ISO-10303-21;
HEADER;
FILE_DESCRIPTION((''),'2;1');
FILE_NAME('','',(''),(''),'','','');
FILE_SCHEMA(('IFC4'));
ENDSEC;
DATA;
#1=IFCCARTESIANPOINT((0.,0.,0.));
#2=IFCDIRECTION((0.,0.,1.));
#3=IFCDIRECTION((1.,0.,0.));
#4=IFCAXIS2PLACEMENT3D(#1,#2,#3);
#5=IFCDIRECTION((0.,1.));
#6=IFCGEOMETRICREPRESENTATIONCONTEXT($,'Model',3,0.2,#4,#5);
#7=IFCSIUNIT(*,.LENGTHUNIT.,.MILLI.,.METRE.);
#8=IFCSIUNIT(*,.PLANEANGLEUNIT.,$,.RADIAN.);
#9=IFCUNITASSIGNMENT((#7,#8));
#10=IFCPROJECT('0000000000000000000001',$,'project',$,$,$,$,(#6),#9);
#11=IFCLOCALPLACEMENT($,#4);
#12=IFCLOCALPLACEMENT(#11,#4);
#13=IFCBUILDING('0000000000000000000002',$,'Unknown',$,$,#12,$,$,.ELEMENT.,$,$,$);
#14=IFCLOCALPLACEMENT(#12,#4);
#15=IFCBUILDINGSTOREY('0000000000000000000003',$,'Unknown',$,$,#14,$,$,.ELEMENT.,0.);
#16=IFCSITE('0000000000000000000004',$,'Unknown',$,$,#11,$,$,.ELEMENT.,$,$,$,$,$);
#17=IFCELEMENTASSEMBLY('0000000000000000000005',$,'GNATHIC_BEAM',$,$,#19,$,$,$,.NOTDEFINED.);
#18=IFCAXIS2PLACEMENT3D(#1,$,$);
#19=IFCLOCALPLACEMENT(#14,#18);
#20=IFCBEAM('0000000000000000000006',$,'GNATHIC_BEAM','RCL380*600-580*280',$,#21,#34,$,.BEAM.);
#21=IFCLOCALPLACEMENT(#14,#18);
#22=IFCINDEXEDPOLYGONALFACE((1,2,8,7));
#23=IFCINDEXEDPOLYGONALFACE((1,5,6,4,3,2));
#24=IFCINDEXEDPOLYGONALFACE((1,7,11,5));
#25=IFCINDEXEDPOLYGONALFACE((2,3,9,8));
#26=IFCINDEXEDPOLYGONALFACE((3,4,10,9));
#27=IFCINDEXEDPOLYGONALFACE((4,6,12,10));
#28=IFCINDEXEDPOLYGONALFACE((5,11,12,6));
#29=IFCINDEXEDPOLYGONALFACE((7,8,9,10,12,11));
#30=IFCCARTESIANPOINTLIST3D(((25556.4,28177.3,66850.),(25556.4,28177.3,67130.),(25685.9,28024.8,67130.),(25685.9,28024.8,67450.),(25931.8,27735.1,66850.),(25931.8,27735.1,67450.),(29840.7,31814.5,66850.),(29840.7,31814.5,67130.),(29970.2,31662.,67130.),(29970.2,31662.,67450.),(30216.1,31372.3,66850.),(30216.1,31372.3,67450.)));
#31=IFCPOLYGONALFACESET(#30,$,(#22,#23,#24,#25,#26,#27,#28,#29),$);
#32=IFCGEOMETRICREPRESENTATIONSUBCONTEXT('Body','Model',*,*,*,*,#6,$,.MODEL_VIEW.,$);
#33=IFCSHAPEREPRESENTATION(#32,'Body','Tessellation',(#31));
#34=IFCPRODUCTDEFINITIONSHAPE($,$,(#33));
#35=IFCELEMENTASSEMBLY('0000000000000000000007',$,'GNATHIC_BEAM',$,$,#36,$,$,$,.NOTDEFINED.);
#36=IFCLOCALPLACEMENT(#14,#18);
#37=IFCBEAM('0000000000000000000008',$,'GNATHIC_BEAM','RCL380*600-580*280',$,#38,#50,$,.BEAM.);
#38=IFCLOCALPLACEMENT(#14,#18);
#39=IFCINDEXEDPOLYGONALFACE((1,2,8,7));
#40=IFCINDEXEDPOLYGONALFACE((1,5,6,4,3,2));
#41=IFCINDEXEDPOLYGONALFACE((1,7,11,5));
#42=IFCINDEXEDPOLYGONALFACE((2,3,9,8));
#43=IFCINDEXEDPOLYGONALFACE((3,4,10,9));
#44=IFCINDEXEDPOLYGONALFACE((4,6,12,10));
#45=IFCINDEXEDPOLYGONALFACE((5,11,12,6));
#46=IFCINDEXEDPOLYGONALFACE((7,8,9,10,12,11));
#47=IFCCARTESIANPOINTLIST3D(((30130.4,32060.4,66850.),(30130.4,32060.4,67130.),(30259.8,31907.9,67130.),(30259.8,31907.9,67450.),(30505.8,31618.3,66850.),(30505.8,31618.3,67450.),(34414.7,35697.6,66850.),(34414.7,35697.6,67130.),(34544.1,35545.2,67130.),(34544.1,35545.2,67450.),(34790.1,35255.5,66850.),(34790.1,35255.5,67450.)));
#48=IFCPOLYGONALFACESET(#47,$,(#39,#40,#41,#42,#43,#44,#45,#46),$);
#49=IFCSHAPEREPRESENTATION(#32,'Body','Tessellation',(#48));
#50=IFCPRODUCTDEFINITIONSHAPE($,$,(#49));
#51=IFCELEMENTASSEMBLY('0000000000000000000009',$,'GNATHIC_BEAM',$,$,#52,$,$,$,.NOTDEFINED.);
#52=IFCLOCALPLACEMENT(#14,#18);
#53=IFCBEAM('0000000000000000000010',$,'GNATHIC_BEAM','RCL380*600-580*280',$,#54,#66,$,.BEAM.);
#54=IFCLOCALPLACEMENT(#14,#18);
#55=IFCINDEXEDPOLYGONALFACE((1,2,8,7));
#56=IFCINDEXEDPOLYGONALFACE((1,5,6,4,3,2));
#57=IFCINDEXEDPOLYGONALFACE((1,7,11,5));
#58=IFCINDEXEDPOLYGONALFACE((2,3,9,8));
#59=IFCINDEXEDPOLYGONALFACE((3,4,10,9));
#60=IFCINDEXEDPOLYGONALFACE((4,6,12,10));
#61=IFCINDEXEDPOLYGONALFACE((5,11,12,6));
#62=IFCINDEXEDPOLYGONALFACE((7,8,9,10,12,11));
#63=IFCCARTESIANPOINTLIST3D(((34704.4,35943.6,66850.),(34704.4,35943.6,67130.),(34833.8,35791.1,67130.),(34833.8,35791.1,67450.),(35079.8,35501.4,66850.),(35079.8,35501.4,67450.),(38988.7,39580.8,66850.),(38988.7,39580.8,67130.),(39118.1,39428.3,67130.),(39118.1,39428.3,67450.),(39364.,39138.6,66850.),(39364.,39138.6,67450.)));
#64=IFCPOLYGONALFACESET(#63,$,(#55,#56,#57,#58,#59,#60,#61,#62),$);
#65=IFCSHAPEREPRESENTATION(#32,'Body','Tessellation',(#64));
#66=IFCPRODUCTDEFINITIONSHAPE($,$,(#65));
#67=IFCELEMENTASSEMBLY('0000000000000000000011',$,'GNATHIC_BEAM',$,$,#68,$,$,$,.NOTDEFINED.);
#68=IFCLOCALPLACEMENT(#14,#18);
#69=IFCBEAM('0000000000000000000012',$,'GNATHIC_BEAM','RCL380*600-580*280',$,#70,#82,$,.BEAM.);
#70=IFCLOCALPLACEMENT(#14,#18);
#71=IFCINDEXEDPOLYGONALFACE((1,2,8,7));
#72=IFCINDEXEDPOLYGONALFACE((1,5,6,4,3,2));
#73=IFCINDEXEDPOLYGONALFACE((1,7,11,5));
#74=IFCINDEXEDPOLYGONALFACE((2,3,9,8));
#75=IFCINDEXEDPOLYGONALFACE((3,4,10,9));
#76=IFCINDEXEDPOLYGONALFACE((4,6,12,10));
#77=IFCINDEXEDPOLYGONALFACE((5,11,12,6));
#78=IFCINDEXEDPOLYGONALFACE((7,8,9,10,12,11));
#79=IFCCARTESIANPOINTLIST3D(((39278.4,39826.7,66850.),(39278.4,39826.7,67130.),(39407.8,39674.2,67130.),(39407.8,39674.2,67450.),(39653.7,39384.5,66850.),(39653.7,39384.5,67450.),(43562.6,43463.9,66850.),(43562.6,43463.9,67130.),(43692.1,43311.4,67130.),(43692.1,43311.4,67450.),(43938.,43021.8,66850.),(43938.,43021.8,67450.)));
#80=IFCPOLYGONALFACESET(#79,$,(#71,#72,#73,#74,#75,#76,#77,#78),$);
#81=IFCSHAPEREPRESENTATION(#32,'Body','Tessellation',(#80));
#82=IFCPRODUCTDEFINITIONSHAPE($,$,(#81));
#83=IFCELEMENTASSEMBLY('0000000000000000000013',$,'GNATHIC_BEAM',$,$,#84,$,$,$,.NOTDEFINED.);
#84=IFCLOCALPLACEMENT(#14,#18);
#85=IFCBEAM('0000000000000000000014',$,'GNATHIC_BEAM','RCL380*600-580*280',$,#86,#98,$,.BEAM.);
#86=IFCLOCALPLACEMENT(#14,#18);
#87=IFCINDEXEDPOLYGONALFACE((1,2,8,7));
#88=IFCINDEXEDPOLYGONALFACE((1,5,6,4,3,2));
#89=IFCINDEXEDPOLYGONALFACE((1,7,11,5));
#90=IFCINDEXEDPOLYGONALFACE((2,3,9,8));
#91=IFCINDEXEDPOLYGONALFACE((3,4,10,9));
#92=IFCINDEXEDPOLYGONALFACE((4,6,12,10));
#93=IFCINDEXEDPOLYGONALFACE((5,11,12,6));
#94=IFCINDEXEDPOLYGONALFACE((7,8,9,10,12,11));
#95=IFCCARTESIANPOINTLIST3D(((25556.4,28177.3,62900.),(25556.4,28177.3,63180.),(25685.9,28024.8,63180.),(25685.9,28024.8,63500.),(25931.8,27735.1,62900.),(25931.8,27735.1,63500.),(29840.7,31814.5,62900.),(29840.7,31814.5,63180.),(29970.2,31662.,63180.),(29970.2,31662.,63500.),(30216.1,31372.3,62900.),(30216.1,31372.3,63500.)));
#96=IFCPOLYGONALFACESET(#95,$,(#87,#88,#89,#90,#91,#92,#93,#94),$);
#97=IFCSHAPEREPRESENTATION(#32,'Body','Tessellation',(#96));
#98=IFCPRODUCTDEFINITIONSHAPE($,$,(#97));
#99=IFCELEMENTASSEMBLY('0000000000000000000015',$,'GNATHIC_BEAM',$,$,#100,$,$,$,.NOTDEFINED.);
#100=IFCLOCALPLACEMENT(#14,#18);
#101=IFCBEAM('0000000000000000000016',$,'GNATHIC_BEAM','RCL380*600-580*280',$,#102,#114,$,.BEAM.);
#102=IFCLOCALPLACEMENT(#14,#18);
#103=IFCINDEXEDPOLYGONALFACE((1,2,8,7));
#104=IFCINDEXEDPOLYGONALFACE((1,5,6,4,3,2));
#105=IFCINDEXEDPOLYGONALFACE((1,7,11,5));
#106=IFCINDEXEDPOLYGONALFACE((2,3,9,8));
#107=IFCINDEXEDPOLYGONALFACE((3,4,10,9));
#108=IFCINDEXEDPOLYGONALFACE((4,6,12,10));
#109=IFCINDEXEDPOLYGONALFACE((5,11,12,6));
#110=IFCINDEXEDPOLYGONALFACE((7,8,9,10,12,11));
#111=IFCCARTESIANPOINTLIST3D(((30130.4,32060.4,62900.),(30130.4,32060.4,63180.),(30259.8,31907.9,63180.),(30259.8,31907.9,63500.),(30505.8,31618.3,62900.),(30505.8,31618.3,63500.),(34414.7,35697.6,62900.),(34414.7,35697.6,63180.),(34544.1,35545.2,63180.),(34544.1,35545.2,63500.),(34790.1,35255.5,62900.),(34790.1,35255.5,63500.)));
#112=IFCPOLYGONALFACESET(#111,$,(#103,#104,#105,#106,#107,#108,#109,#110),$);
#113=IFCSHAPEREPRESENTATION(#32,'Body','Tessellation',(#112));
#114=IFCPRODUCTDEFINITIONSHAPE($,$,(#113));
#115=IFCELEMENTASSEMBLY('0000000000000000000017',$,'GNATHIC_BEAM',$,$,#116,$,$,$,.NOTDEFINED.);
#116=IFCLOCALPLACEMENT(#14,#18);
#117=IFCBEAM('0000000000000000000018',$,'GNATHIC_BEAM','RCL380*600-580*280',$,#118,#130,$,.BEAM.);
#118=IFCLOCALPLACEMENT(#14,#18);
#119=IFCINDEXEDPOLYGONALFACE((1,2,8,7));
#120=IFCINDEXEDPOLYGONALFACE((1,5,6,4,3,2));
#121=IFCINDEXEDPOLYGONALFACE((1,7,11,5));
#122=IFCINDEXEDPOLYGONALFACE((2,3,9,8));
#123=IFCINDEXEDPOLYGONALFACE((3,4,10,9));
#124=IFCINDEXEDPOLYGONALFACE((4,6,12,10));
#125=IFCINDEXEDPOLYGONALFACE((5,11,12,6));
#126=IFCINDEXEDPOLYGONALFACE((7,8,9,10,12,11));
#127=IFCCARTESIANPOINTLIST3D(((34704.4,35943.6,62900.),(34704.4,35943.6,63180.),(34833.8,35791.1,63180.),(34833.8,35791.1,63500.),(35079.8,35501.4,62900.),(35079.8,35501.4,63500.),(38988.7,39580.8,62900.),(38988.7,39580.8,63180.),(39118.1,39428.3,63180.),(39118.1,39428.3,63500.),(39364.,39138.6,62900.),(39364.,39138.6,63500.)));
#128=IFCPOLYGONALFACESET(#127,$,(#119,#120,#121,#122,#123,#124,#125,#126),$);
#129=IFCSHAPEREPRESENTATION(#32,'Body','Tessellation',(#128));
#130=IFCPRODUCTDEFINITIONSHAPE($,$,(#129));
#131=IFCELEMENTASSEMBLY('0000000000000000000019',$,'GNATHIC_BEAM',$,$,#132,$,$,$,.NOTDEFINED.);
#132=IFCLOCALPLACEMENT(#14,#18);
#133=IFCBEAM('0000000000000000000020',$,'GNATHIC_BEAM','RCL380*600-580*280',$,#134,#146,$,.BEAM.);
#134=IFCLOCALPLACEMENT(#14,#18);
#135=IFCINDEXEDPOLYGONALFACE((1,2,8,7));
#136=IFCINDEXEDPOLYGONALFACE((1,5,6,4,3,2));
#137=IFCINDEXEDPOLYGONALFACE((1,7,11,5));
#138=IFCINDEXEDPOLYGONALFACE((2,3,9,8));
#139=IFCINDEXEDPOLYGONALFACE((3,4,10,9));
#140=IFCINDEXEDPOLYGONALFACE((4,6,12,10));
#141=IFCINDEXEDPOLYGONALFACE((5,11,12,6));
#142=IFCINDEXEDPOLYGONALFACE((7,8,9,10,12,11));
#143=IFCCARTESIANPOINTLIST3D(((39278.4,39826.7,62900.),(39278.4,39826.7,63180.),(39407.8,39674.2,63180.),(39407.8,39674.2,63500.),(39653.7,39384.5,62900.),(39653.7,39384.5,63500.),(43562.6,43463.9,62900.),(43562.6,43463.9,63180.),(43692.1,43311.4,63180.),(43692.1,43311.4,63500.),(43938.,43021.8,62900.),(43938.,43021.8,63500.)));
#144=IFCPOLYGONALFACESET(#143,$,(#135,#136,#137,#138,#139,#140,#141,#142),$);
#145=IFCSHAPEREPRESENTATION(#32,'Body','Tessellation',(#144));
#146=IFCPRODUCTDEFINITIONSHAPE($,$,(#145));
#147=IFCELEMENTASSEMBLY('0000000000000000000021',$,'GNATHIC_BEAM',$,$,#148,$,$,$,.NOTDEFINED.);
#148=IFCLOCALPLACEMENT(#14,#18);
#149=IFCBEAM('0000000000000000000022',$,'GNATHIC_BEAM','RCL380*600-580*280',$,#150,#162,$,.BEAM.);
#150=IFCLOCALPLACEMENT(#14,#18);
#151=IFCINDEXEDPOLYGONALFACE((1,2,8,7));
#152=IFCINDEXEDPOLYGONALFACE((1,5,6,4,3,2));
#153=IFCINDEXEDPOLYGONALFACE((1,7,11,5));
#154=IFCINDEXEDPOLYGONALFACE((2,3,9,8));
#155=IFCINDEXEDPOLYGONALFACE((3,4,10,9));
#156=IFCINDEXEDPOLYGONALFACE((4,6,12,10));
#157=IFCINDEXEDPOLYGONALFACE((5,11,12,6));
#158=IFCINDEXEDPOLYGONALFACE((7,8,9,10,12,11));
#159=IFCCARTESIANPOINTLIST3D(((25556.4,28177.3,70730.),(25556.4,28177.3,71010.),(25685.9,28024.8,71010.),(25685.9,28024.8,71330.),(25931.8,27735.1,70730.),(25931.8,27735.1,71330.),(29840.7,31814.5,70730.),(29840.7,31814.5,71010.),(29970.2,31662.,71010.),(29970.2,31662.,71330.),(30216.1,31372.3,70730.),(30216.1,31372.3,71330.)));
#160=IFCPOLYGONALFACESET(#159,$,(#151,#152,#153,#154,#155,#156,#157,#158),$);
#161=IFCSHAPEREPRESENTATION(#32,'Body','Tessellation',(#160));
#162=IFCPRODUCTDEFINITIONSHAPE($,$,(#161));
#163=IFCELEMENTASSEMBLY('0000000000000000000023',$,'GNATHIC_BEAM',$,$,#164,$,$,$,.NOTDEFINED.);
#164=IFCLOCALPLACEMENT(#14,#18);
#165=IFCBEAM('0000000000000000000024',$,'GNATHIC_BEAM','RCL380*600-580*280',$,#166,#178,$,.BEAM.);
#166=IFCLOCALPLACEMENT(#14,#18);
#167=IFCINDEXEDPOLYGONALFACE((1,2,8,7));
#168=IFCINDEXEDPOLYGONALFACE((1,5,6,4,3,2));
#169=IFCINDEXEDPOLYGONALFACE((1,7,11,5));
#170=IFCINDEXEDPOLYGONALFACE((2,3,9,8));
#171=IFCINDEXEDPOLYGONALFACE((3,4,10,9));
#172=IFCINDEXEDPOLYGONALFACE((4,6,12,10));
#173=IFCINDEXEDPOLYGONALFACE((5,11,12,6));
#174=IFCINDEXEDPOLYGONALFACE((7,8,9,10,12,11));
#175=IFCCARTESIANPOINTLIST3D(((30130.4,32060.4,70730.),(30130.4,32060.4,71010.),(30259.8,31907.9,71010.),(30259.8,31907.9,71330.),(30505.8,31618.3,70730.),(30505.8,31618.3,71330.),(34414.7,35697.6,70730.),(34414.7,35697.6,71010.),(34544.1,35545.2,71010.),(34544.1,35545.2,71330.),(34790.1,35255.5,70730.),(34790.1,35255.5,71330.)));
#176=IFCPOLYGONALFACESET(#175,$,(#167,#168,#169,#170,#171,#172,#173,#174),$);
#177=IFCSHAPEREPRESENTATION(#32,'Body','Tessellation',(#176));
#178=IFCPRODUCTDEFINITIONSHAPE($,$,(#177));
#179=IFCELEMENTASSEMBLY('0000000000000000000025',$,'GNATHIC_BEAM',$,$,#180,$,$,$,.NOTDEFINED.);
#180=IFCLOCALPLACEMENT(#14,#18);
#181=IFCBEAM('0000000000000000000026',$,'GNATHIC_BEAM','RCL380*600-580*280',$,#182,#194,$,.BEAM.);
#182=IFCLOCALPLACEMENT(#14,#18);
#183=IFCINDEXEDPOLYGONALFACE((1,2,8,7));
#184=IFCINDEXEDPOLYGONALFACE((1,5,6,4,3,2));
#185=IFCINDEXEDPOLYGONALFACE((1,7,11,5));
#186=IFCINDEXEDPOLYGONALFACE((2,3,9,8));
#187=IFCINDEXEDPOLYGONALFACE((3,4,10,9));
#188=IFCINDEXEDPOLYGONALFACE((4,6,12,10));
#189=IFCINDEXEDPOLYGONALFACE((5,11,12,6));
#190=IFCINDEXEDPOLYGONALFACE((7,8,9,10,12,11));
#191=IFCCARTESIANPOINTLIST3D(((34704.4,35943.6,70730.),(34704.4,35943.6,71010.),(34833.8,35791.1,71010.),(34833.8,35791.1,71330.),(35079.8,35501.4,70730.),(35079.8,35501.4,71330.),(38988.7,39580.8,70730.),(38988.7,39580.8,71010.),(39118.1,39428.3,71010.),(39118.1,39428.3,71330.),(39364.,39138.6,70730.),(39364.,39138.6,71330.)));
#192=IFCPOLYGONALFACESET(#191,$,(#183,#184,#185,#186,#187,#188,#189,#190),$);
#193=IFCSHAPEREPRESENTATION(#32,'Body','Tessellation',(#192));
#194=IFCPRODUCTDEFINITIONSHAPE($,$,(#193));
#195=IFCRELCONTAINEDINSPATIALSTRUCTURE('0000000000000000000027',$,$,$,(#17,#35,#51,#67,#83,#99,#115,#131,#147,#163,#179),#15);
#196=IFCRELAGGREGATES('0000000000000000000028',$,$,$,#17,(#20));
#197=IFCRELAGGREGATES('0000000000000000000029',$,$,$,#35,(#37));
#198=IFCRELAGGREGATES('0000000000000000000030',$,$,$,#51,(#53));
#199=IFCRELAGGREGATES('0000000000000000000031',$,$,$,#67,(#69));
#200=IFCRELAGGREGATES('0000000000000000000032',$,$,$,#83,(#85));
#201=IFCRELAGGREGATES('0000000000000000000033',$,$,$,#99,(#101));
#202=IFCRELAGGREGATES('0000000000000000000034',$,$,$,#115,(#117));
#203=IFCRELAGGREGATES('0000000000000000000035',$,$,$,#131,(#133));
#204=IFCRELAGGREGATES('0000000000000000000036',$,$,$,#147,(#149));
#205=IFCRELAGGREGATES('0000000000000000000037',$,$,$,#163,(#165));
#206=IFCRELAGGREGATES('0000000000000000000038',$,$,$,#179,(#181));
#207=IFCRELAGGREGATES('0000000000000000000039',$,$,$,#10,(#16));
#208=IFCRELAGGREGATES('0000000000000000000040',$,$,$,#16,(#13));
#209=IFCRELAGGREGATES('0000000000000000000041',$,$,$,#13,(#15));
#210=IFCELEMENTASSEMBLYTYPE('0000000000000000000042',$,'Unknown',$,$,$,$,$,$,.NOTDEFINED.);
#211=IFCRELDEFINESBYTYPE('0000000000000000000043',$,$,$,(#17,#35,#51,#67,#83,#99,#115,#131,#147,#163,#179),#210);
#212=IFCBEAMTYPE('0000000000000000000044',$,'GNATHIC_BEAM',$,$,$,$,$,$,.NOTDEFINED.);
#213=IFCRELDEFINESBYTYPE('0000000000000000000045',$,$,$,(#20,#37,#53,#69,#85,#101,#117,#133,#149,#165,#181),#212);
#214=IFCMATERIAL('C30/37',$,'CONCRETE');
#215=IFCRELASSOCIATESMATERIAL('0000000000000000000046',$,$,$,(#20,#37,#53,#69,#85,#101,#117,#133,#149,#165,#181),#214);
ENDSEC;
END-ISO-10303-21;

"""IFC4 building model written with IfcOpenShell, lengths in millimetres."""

from ifc_helpers import new_model, si_unit, direction, frame, origin_with_axes, place, context, subcontext, project, spatial, polyline, outline, extrude, material, material_profile, profile_set, profile_usage, type_object, element, aggregate, save


model = new_model("IFC4")

# Units and contexts
model_context = context("Model", 3, precision=0.2, world=origin_with_axes(), true_north=direction((0.0, 1.0)))
body_context = subcontext(model_context, "Body", "Model", "MODEL_VIEW")
ifc_project = project(units=[si_unit("LENGTHUNIT", "METRE", prefix="MILLI"), si_unit("PLANEANGLEUNIT", "RADIAN")], contexts=[model_context])

# Site, building, storey
site_placement = place(None, origin_with_axes())
site = spatial("IfcSite", under=ifc_project, at=site_placement, Name="Unknown", CompositionType="ELEMENT")
building_placement = place(site_placement, origin_with_axes())
building = spatial("IfcBuilding", under=site, at=building_placement, Name="Unknown", CompositionType="ELEMENT")
storey_placement = place(building_placement, origin_with_axes())
storey = spatial("IfcBuildingStorey", under=building, at=storey_placement, Name="Unknown", CompositionType="ELEMENT", Elevation=0.0)

# Shared definitions
element_assembly_type = type_object("IfcElementAssemblyType", Name="Unknown", PredefinedType="NOTDEFINED")

# Element assemblies, beams
ifc_material_1 = material(Name="C30/37", Category="CONCRETE")
assembly_1_placement = place(storey_placement, frame((30093.1, 31517.2, 67150.0), z_axis=(-0.64719, 0.762329, 0.0), x_axis=(-0.762329, -0.64719, 0.0)))
assembly_1 = element("IfcElementAssembly", 1, at=assembly_1_placement, inside=storey, type_object=element_assembly_type, Name="GNATHIC_BEAM", PredefinedType="NOTDEFINED")
ifc_material_profile_1 = material_profile(ifc_material_1, outline(polyline([(-190.0, -300.0), (390.0, -300.0), (390.0, -20.0), (190.0, -20.0), (190.0, 300.0), (-190.0, 300.0), (-190.0, -300.0)])), Name="RCL380*600-580*280")
ifc_profile_set_1 = profile_set([ifc_material_profile_1])
ifc_profile_usage_1 = profile_usage(ifc_profile_set_1, cardinal=2)
beam_type_1 = type_object("IfcBeamType", Name="GNATHIC_BEAM")
beam_1_placement = place(assembly_1_placement, origin_with_axes())
beam_1 = element("IfcBeam", 2, at=beam_1_placement, type_object=beam_type_1, material=ifc_profile_usage_1, Name="GNATHIC_BEAM", Description="RCL380*600-580*280", PredefinedType="BEAM", context=body_context, shape_type="SolidModel", body=[
    extrude(outline(polyline([(-190.0, -300.0), (390.0, -300.0), (390.0, -20.0), (190.0, -20.0), (190.0, 300.0), (-190.0, 300.0), (-190.0, -300.0)])), frame((0.0, 0.0, 0.0), z_axis=(-1.0, 0.0, 0.0), x_axis=(0.0, 0.0, 1.0)), (0.0, 0.0, -1.0), 5620.0),
])
aggregate(assembly_1, [beam_1])
assembly_2_placement = place(storey_placement, frame((34667.1, 35400.3, 67150.0), z_axis=(-0.64719, 0.762329, 0.0), x_axis=(-0.762329, -0.64719, 0.0)))
assembly_2 = element("IfcElementAssembly", 3, at=assembly_2_placement, inside=storey, type_object=element_assembly_type, Name="GNATHIC_BEAM", PredefinedType="NOTDEFINED")
beam_2_placement = place(assembly_2_placement, origin_with_axes())
beam_2 = element("IfcBeam", 4, at=beam_2_placement, type_object=beam_type_1, material=ifc_profile_usage_1, Name="GNATHIC_BEAM", Description="RCL380*600-580*280", PredefinedType="BEAM", context=body_context, shape_type="SolidModel", body=[
    extrude(outline(polyline([(-190.0, -300.0), (390.0, -300.0), (390.0, -20.0), (190.0, -20.0), (190.0, 300.0), (-190.0, 300.0), (-190.0, -300.0)])), frame((0.0, 0.0, 0.0), z_axis=(-1.0, 0.0, 0.0), x_axis=(0.0, 0.0, 1.0)), (0.0, 0.0, -1.0), 5620.0),
])
aggregate(assembly_2, [beam_2])
assembly_3_placement = place(storey_placement, frame((39241.1, 39283.5, 67150.0), z_axis=(-0.64719, 0.762329, 0.0), x_axis=(-0.762329, -0.64719, 0.0)))
assembly_3 = element("IfcElementAssembly", 5, at=assembly_3_placement, inside=storey, type_object=element_assembly_type, Name="GNATHIC_BEAM", PredefinedType="NOTDEFINED")
beam_3_placement = place(assembly_3_placement, origin_with_axes())
beam_3 = element("IfcBeam", 6, at=beam_3_placement, type_object=beam_type_1, material=ifc_profile_usage_1, Name="GNATHIC_BEAM", Description="RCL380*600-580*280", PredefinedType="BEAM", context=body_context, shape_type="SolidModel", body=[
    extrude(outline(polyline([(-190.0, -300.0), (390.0, -300.0), (390.0, -20.0), (190.0, -20.0), (190.0, 300.0), (-190.0, 300.0), (-190.0, -300.0)])), frame((0.0, 0.0, 0.0), z_axis=(-1.0, 0.0, 0.0), x_axis=(0.0, 0.0, 1.0)), (0.0, 0.0, -1.0), 5620.0),
])
aggregate(assembly_3, [beam_3])
assembly_4_placement = place(storey_placement, frame((43815.0, 43166.6, 67150.0), z_axis=(-0.64719, 0.762329, 0.0), x_axis=(-0.762329, -0.64719, 0.0)))
assembly_4 = element("IfcElementAssembly", 7, at=assembly_4_placement, inside=storey, type_object=element_assembly_type, Name="GNATHIC_BEAM", PredefinedType="NOTDEFINED")
beam_4_placement = place(assembly_4_placement, origin_with_axes())
beam_4 = element("IfcBeam", 8, at=beam_4_placement, type_object=beam_type_1, material=ifc_profile_usage_1, Name="GNATHIC_BEAM", Description="RCL380*600-580*280", PredefinedType="BEAM", context=body_context, shape_type="SolidModel", body=[
    extrude(outline(polyline([(-190.0, -300.0), (390.0, -300.0), (390.0, -20.0), (190.0, -20.0), (190.0, 300.0), (-190.0, 300.0), (-190.0, -300.0)])), frame((0.0, 0.0, 0.0), z_axis=(-1.0, 0.0, 0.0), x_axis=(0.0, 0.0, 1.0)), (0.0, 0.0, -1.0), 5620.0),
])
aggregate(assembly_4, [beam_4])
assembly_5_placement = place(storey_placement, frame((30093.1, 31517.2, 63200.0), z_axis=(-0.64719, 0.762329, 0.0), x_axis=(-0.762329, -0.64719, 0.0)))
assembly_5 = element("IfcElementAssembly", 9, at=assembly_5_placement, inside=storey, type_object=element_assembly_type, Name="GNATHIC_BEAM", PredefinedType="NOTDEFINED")
beam_5_placement = place(assembly_5_placement, origin_with_axes())
beam_5 = element("IfcBeam", 10, at=beam_5_placement, type_object=beam_type_1, material=ifc_profile_usage_1, Name="GNATHIC_BEAM", Description="RCL380*600-580*280", PredefinedType="BEAM", context=body_context, shape_type="SolidModel", body=[
    extrude(outline(polyline([(-190.0, -300.0), (390.0, -300.0), (390.0, -20.0), (190.0, -20.0), (190.0, 300.0), (-190.0, 300.0), (-190.0, -300.0)])), frame((0.0, 0.0, 0.0), z_axis=(-1.0, 0.0, 0.0), x_axis=(0.0, 0.0, 1.0)), (0.0, 0.0, -1.0), 5620.0),
])
aggregate(assembly_5, [beam_5])
assembly_6_placement = place(storey_placement, frame((34667.1, 35400.3, 63200.0), z_axis=(-0.64719, 0.762329, 0.0), x_axis=(-0.762329, -0.64719, 0.0)))
assembly_6 = element("IfcElementAssembly", 11, at=assembly_6_placement, inside=storey, type_object=element_assembly_type, Name="GNATHIC_BEAM", PredefinedType="NOTDEFINED")
beam_6_placement = place(assembly_6_placement, origin_with_axes())
beam_6 = element("IfcBeam", 12, at=beam_6_placement, type_object=beam_type_1, material=ifc_profile_usage_1, Name="GNATHIC_BEAM", Description="RCL380*600-580*280", PredefinedType="BEAM", context=body_context, shape_type="SolidModel", body=[
    extrude(outline(polyline([(-190.0, -300.0), (390.0, -300.0), (390.0, -20.0), (190.0, -20.0), (190.0, 300.0), (-190.0, 300.0), (-190.0, -300.0)])), frame((0.0, 0.0, 0.0), z_axis=(-1.0, 0.0, 0.0), x_axis=(0.0, 0.0, 1.0)), (0.0, 0.0, -1.0), 5620.0),
])
aggregate(assembly_6, [beam_6])
assembly_7_placement = place(storey_placement, frame((39241.1, 39283.5, 63200.0), z_axis=(-0.64719, 0.762329, 0.0), x_axis=(-0.762329, -0.64719, 0.0)))
assembly_7 = element("IfcElementAssembly", 13, at=assembly_7_placement, inside=storey, type_object=element_assembly_type, Name="GNATHIC_BEAM", PredefinedType="NOTDEFINED")
beam_7_placement = place(assembly_7_placement, origin_with_axes())
beam_7 = element("IfcBeam", 14, at=beam_7_placement, type_object=beam_type_1, material=ifc_profile_usage_1, Name="GNATHIC_BEAM", Description="RCL380*600-580*280", PredefinedType="BEAM", context=body_context, shape_type="SolidModel", body=[
    extrude(outline(polyline([(-190.0, -300.0), (390.0, -300.0), (390.0, -20.0), (190.0, -20.0), (190.0, 300.0), (-190.0, 300.0), (-190.0, -300.0)])), frame((0.0, 0.0, 0.0), z_axis=(-1.0, 0.0, 0.0), x_axis=(0.0, 0.0, 1.0)), (0.0, 0.0, -1.0), 5620.0),
])
aggregate(assembly_7, [beam_7])
assembly_8_placement = place(storey_placement, frame((43815.0, 43166.6, 63200.0), z_axis=(-0.64719, 0.762329, 0.0), x_axis=(-0.762329, -0.64719, 0.0)))
assembly_8 = element("IfcElementAssembly", 15, at=assembly_8_placement, inside=storey, type_object=element_assembly_type, Name="GNATHIC_BEAM", PredefinedType="NOTDEFINED")
beam_8_placement = place(assembly_8_placement, origin_with_axes())
beam_8 = element("IfcBeam", 16, at=beam_8_placement, type_object=beam_type_1, material=ifc_profile_usage_1, Name="GNATHIC_BEAM", Description="RCL380*600-580*280", PredefinedType="BEAM", context=body_context, shape_type="SolidModel", body=[
    extrude(outline(polyline([(-190.0, -300.0), (390.0, -300.0), (390.0, -20.0), (190.0, -20.0), (190.0, 300.0), (-190.0, 300.0), (-190.0, -300.0)])), frame((0.0, 0.0, 0.0), z_axis=(-1.0, 0.0, 0.0), x_axis=(0.0, 0.0, 1.0)), (0.0, 0.0, -1.0), 5620.0),
])
aggregate(assembly_8, [beam_8])
assembly_9_placement = place(storey_placement, frame((30093.1, 31517.2, 71030.0), z_axis=(-0.64719, 0.762329, 0.0), x_axis=(-0.762329, -0.64719, 0.0)))
assembly_9 = element("IfcElementAssembly", 17, at=assembly_9_placement, inside=storey, type_object=element_assembly_type, Name="GNATHIC_BEAM", PredefinedType="NOTDEFINED")
beam_9_placement = place(assembly_9_placement, origin_with_axes())
beam_9 = element("IfcBeam", 18, at=beam_9_placement, type_object=beam_type_1, material=ifc_profile_usage_1, Name="GNATHIC_BEAM", Description="RCL380*600-580*280", PredefinedType="BEAM", context=body_context, shape_type="SolidModel", body=[
    extrude(outline(polyline([(-190.0, -300.0), (390.0, -300.0), (390.0, -20.0), (190.0, -20.0), (190.0, 300.0), (-190.0, 300.0), (-190.0, -300.0)])), frame((0.0, 0.0, 0.0), z_axis=(-1.0, 0.0, 0.0), x_axis=(0.0, 0.0, 1.0)), (0.0, 0.0, -1.0), 5620.0),
])
aggregate(assembly_9, [beam_9])
assembly_10_placement = place(storey_placement, frame((34667.1, 35400.3, 71030.0), z_axis=(-0.64719, 0.762329, 0.0), x_axis=(-0.762329, -0.64719, 0.0)))
assembly_10 = element("IfcElementAssembly", 19, at=assembly_10_placement, inside=storey, type_object=element_assembly_type, Name="GNATHIC_BEAM", PredefinedType="NOTDEFINED")
beam_10_placement = place(assembly_10_placement, origin_with_axes())
beam_10 = element("IfcBeam", 20, at=beam_10_placement, type_object=beam_type_1, material=ifc_profile_usage_1, Name="GNATHIC_BEAM", Description="RCL380*600-580*280", PredefinedType="BEAM", context=body_context, shape_type="SolidModel", body=[
    extrude(outline(polyline([(-190.0, -300.0), (390.0, -300.0), (390.0, -20.0), (190.0, -20.0), (190.0, 300.0), (-190.0, 300.0), (-190.0, -300.0)])), frame((0.0, 0.0, 0.0), z_axis=(-1.0, 0.0, 0.0), x_axis=(0.0, 0.0, 1.0)), (0.0, 0.0, -1.0), 5620.0),
])
aggregate(assembly_10, [beam_10])
assembly_11_placement = place(storey_placement, frame((39241.1, 39283.5, 71030.0), z_axis=(-0.64719, 0.762329, 0.0), x_axis=(-0.762329, -0.64719, 0.0)))
assembly_11 = element("IfcElementAssembly", 21, at=assembly_11_placement, inside=storey, type_object=element_assembly_type, Name="GNATHIC_BEAM", PredefinedType="NOTDEFINED")
beam_11_placement = place(assembly_11_placement, origin_with_axes())
beam_11 = element("IfcBeam", 22, at=beam_11_placement, type_object=beam_type_1, material=ifc_profile_usage_1, Name="GNATHIC_BEAM", Description="RCL380*600-580*280", PredefinedType="BEAM", context=body_context, shape_type="SolidModel", body=[
    extrude(outline(polyline([(-190.0, -300.0), (390.0, -300.0), (390.0, -20.0), (190.0, -20.0), (190.0, 300.0), (-190.0, 300.0), (-190.0, -300.0)])), frame((0.0, 0.0, 0.0), z_axis=(-1.0, 0.0, 0.0), x_axis=(0.0, 0.0, 1.0)), (0.0, 0.0, -1.0), 5620.0),
])
aggregate(assembly_11, [beam_11])

save(model, "model.ifc")
